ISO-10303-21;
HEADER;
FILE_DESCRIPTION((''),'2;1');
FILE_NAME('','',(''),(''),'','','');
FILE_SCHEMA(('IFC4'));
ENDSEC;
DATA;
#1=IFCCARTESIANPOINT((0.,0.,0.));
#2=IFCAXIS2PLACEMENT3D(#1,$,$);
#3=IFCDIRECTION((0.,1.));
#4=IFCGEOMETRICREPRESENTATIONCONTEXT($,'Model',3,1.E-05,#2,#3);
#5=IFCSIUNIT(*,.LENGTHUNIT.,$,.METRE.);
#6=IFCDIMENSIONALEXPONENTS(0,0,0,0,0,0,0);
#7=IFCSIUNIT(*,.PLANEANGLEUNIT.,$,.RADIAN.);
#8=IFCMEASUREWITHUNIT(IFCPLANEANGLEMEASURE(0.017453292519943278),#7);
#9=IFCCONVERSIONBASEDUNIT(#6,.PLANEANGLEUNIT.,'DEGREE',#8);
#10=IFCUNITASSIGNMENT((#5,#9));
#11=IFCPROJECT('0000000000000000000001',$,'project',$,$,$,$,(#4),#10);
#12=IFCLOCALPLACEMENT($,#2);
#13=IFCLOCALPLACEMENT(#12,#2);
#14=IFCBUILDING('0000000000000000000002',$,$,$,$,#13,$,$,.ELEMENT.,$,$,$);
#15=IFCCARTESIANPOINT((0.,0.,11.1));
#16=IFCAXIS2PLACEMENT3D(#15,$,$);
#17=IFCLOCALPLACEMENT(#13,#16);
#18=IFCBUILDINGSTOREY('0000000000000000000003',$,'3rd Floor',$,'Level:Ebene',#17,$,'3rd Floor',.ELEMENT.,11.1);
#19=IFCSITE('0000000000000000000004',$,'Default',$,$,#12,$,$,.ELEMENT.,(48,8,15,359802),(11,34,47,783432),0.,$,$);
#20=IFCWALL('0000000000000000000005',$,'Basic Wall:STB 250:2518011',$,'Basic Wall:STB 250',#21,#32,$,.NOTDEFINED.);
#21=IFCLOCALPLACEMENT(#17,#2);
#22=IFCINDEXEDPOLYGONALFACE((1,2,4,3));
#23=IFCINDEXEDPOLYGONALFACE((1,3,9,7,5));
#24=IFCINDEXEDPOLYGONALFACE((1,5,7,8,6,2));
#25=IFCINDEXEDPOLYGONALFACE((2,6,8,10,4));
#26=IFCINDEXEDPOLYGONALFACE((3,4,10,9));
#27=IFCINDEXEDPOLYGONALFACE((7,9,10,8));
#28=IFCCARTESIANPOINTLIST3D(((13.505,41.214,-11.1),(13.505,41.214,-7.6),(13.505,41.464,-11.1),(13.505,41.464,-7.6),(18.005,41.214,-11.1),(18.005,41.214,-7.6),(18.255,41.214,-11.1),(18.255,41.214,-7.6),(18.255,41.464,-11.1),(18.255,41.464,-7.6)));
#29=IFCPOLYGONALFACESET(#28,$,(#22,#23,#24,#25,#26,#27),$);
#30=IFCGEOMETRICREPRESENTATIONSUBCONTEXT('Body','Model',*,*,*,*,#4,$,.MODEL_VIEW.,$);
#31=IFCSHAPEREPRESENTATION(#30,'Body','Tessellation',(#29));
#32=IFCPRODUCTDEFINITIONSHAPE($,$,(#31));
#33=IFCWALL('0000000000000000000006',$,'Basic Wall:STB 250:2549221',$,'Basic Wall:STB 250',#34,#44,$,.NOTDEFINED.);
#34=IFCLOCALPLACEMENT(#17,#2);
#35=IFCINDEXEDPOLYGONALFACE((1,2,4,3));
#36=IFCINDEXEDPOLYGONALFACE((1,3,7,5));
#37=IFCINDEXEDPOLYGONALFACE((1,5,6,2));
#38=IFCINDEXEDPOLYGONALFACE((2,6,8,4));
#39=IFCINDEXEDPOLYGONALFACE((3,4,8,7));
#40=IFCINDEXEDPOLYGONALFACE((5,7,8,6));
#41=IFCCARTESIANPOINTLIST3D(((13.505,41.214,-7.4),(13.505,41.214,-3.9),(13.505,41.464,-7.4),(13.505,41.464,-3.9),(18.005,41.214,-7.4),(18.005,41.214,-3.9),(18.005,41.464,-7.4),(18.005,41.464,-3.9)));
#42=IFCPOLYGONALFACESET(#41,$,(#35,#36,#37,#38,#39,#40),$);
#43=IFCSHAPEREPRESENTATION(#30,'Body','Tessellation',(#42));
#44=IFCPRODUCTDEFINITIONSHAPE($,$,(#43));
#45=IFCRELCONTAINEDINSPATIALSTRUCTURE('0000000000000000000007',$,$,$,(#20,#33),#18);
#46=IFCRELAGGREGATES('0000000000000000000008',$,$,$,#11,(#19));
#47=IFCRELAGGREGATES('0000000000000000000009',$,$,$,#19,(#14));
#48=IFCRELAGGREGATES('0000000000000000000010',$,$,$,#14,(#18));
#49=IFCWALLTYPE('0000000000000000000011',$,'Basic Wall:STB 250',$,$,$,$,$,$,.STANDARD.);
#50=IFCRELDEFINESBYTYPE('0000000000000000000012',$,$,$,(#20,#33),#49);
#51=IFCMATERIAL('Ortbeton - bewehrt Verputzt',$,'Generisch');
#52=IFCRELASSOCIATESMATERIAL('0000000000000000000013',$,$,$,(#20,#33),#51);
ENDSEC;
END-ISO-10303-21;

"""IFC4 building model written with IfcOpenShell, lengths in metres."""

from ifc_helpers import new_model, entity, si_unit, converted_unit, direction, frame, origin, place, context, subcontext, project, spatial, indexed_curve, outline, extrude, material, type_object, element, save


model = new_model("IFC4")

# Units and contexts
model_context = context("Model", 3, precision=1e-05, world=origin(), true_north=direction((0.0, 1.0)))
body_context = subcontext(model_context, "Body", "Model", "MODEL_VIEW")
ifc_project = project(units=[si_unit("LENGTHUNIT", "METRE"), converted_unit("PLANEANGLEUNIT", "DEGREE", entity("IfcPlaneAngleMeasure", 0.017453292519943278), si_unit("PLANEANGLEUNIT", "RADIAN"), dimensions=[0, 0, 0, 0, 0, 0, 0])], contexts=[model_context])

# Site, building, storey
site_placement = place(None, origin())
site = spatial("IfcSite", under=ifc_project, at=site_placement, Name="Default", CompositionType="ELEMENT", RefLatitude=(48, 8, 15, 359802), RefLongitude=(11, 34, 47, 783432), RefElevation=0.0)
building_placement = place(site_placement, origin())
building = spatial("IfcBuilding", under=site, at=building_placement, CompositionType="ELEMENT")
storey_placement = place(building_placement, frame((0.0, 0.0, 11.1)))
storey = spatial("IfcBuildingStorey", under=building, at=storey_placement, Name="3rd Floor", ObjectType="Level:Ebene", LongName="3rd Floor", CompositionType="ELEMENT", Elevation=11.1)

# Walls
ifc_material_1 = material(Name="Ortbeton - bewehrt Verputzt", Category="Generisch")
wall_type = type_object("IfcWallType", Name="Basic Wall:STB 250", PredefinedType="STANDARD")
wall_1_placement = place(storey_placement, frame((13.505, 41.339, -11.1)))
element("IfcWall", 1, at=wall_1_placement, inside=storey, type_object=wall_type, material=ifc_material_1, Name="Basic Wall:STB 250:2518011", ObjectType="Basic Wall:STB 250", PredefinedType="NOTDEFINED", context=body_context, shape_type="SweptSolid", body=[
    extrude(outline(indexed_curve([(4.75, -0.125), (4.75, 0.125), (0.0, 0.125), (0.0, -0.125), (4.5, -0.125), (4.75, -0.125)], self_intersect=False)), origin(), (0.0, 0.0, 1.0), 3.5),
])
wall_2_placement = place(storey_placement, frame((13.505, 41.339, -7.4)))
element("IfcWall", 2, at=wall_2_placement, inside=storey, type_object=wall_type, material=ifc_material_1, Name="Basic Wall:STB 250:2549221", ObjectType="Basic Wall:STB 250", PredefinedType="NOTDEFINED", context=body_context, shape_type="SweptSolid", body=[
    extrude(outline(indexed_curve([(4.5, -0.125), (4.5, 0.125), (0.0, 0.125), (0.0, -0.125), (4.5, -0.125)], self_intersect=False)), origin(), (0.0, 0.0, 1.0), 3.5),
])

save(model, "model.ifc")
